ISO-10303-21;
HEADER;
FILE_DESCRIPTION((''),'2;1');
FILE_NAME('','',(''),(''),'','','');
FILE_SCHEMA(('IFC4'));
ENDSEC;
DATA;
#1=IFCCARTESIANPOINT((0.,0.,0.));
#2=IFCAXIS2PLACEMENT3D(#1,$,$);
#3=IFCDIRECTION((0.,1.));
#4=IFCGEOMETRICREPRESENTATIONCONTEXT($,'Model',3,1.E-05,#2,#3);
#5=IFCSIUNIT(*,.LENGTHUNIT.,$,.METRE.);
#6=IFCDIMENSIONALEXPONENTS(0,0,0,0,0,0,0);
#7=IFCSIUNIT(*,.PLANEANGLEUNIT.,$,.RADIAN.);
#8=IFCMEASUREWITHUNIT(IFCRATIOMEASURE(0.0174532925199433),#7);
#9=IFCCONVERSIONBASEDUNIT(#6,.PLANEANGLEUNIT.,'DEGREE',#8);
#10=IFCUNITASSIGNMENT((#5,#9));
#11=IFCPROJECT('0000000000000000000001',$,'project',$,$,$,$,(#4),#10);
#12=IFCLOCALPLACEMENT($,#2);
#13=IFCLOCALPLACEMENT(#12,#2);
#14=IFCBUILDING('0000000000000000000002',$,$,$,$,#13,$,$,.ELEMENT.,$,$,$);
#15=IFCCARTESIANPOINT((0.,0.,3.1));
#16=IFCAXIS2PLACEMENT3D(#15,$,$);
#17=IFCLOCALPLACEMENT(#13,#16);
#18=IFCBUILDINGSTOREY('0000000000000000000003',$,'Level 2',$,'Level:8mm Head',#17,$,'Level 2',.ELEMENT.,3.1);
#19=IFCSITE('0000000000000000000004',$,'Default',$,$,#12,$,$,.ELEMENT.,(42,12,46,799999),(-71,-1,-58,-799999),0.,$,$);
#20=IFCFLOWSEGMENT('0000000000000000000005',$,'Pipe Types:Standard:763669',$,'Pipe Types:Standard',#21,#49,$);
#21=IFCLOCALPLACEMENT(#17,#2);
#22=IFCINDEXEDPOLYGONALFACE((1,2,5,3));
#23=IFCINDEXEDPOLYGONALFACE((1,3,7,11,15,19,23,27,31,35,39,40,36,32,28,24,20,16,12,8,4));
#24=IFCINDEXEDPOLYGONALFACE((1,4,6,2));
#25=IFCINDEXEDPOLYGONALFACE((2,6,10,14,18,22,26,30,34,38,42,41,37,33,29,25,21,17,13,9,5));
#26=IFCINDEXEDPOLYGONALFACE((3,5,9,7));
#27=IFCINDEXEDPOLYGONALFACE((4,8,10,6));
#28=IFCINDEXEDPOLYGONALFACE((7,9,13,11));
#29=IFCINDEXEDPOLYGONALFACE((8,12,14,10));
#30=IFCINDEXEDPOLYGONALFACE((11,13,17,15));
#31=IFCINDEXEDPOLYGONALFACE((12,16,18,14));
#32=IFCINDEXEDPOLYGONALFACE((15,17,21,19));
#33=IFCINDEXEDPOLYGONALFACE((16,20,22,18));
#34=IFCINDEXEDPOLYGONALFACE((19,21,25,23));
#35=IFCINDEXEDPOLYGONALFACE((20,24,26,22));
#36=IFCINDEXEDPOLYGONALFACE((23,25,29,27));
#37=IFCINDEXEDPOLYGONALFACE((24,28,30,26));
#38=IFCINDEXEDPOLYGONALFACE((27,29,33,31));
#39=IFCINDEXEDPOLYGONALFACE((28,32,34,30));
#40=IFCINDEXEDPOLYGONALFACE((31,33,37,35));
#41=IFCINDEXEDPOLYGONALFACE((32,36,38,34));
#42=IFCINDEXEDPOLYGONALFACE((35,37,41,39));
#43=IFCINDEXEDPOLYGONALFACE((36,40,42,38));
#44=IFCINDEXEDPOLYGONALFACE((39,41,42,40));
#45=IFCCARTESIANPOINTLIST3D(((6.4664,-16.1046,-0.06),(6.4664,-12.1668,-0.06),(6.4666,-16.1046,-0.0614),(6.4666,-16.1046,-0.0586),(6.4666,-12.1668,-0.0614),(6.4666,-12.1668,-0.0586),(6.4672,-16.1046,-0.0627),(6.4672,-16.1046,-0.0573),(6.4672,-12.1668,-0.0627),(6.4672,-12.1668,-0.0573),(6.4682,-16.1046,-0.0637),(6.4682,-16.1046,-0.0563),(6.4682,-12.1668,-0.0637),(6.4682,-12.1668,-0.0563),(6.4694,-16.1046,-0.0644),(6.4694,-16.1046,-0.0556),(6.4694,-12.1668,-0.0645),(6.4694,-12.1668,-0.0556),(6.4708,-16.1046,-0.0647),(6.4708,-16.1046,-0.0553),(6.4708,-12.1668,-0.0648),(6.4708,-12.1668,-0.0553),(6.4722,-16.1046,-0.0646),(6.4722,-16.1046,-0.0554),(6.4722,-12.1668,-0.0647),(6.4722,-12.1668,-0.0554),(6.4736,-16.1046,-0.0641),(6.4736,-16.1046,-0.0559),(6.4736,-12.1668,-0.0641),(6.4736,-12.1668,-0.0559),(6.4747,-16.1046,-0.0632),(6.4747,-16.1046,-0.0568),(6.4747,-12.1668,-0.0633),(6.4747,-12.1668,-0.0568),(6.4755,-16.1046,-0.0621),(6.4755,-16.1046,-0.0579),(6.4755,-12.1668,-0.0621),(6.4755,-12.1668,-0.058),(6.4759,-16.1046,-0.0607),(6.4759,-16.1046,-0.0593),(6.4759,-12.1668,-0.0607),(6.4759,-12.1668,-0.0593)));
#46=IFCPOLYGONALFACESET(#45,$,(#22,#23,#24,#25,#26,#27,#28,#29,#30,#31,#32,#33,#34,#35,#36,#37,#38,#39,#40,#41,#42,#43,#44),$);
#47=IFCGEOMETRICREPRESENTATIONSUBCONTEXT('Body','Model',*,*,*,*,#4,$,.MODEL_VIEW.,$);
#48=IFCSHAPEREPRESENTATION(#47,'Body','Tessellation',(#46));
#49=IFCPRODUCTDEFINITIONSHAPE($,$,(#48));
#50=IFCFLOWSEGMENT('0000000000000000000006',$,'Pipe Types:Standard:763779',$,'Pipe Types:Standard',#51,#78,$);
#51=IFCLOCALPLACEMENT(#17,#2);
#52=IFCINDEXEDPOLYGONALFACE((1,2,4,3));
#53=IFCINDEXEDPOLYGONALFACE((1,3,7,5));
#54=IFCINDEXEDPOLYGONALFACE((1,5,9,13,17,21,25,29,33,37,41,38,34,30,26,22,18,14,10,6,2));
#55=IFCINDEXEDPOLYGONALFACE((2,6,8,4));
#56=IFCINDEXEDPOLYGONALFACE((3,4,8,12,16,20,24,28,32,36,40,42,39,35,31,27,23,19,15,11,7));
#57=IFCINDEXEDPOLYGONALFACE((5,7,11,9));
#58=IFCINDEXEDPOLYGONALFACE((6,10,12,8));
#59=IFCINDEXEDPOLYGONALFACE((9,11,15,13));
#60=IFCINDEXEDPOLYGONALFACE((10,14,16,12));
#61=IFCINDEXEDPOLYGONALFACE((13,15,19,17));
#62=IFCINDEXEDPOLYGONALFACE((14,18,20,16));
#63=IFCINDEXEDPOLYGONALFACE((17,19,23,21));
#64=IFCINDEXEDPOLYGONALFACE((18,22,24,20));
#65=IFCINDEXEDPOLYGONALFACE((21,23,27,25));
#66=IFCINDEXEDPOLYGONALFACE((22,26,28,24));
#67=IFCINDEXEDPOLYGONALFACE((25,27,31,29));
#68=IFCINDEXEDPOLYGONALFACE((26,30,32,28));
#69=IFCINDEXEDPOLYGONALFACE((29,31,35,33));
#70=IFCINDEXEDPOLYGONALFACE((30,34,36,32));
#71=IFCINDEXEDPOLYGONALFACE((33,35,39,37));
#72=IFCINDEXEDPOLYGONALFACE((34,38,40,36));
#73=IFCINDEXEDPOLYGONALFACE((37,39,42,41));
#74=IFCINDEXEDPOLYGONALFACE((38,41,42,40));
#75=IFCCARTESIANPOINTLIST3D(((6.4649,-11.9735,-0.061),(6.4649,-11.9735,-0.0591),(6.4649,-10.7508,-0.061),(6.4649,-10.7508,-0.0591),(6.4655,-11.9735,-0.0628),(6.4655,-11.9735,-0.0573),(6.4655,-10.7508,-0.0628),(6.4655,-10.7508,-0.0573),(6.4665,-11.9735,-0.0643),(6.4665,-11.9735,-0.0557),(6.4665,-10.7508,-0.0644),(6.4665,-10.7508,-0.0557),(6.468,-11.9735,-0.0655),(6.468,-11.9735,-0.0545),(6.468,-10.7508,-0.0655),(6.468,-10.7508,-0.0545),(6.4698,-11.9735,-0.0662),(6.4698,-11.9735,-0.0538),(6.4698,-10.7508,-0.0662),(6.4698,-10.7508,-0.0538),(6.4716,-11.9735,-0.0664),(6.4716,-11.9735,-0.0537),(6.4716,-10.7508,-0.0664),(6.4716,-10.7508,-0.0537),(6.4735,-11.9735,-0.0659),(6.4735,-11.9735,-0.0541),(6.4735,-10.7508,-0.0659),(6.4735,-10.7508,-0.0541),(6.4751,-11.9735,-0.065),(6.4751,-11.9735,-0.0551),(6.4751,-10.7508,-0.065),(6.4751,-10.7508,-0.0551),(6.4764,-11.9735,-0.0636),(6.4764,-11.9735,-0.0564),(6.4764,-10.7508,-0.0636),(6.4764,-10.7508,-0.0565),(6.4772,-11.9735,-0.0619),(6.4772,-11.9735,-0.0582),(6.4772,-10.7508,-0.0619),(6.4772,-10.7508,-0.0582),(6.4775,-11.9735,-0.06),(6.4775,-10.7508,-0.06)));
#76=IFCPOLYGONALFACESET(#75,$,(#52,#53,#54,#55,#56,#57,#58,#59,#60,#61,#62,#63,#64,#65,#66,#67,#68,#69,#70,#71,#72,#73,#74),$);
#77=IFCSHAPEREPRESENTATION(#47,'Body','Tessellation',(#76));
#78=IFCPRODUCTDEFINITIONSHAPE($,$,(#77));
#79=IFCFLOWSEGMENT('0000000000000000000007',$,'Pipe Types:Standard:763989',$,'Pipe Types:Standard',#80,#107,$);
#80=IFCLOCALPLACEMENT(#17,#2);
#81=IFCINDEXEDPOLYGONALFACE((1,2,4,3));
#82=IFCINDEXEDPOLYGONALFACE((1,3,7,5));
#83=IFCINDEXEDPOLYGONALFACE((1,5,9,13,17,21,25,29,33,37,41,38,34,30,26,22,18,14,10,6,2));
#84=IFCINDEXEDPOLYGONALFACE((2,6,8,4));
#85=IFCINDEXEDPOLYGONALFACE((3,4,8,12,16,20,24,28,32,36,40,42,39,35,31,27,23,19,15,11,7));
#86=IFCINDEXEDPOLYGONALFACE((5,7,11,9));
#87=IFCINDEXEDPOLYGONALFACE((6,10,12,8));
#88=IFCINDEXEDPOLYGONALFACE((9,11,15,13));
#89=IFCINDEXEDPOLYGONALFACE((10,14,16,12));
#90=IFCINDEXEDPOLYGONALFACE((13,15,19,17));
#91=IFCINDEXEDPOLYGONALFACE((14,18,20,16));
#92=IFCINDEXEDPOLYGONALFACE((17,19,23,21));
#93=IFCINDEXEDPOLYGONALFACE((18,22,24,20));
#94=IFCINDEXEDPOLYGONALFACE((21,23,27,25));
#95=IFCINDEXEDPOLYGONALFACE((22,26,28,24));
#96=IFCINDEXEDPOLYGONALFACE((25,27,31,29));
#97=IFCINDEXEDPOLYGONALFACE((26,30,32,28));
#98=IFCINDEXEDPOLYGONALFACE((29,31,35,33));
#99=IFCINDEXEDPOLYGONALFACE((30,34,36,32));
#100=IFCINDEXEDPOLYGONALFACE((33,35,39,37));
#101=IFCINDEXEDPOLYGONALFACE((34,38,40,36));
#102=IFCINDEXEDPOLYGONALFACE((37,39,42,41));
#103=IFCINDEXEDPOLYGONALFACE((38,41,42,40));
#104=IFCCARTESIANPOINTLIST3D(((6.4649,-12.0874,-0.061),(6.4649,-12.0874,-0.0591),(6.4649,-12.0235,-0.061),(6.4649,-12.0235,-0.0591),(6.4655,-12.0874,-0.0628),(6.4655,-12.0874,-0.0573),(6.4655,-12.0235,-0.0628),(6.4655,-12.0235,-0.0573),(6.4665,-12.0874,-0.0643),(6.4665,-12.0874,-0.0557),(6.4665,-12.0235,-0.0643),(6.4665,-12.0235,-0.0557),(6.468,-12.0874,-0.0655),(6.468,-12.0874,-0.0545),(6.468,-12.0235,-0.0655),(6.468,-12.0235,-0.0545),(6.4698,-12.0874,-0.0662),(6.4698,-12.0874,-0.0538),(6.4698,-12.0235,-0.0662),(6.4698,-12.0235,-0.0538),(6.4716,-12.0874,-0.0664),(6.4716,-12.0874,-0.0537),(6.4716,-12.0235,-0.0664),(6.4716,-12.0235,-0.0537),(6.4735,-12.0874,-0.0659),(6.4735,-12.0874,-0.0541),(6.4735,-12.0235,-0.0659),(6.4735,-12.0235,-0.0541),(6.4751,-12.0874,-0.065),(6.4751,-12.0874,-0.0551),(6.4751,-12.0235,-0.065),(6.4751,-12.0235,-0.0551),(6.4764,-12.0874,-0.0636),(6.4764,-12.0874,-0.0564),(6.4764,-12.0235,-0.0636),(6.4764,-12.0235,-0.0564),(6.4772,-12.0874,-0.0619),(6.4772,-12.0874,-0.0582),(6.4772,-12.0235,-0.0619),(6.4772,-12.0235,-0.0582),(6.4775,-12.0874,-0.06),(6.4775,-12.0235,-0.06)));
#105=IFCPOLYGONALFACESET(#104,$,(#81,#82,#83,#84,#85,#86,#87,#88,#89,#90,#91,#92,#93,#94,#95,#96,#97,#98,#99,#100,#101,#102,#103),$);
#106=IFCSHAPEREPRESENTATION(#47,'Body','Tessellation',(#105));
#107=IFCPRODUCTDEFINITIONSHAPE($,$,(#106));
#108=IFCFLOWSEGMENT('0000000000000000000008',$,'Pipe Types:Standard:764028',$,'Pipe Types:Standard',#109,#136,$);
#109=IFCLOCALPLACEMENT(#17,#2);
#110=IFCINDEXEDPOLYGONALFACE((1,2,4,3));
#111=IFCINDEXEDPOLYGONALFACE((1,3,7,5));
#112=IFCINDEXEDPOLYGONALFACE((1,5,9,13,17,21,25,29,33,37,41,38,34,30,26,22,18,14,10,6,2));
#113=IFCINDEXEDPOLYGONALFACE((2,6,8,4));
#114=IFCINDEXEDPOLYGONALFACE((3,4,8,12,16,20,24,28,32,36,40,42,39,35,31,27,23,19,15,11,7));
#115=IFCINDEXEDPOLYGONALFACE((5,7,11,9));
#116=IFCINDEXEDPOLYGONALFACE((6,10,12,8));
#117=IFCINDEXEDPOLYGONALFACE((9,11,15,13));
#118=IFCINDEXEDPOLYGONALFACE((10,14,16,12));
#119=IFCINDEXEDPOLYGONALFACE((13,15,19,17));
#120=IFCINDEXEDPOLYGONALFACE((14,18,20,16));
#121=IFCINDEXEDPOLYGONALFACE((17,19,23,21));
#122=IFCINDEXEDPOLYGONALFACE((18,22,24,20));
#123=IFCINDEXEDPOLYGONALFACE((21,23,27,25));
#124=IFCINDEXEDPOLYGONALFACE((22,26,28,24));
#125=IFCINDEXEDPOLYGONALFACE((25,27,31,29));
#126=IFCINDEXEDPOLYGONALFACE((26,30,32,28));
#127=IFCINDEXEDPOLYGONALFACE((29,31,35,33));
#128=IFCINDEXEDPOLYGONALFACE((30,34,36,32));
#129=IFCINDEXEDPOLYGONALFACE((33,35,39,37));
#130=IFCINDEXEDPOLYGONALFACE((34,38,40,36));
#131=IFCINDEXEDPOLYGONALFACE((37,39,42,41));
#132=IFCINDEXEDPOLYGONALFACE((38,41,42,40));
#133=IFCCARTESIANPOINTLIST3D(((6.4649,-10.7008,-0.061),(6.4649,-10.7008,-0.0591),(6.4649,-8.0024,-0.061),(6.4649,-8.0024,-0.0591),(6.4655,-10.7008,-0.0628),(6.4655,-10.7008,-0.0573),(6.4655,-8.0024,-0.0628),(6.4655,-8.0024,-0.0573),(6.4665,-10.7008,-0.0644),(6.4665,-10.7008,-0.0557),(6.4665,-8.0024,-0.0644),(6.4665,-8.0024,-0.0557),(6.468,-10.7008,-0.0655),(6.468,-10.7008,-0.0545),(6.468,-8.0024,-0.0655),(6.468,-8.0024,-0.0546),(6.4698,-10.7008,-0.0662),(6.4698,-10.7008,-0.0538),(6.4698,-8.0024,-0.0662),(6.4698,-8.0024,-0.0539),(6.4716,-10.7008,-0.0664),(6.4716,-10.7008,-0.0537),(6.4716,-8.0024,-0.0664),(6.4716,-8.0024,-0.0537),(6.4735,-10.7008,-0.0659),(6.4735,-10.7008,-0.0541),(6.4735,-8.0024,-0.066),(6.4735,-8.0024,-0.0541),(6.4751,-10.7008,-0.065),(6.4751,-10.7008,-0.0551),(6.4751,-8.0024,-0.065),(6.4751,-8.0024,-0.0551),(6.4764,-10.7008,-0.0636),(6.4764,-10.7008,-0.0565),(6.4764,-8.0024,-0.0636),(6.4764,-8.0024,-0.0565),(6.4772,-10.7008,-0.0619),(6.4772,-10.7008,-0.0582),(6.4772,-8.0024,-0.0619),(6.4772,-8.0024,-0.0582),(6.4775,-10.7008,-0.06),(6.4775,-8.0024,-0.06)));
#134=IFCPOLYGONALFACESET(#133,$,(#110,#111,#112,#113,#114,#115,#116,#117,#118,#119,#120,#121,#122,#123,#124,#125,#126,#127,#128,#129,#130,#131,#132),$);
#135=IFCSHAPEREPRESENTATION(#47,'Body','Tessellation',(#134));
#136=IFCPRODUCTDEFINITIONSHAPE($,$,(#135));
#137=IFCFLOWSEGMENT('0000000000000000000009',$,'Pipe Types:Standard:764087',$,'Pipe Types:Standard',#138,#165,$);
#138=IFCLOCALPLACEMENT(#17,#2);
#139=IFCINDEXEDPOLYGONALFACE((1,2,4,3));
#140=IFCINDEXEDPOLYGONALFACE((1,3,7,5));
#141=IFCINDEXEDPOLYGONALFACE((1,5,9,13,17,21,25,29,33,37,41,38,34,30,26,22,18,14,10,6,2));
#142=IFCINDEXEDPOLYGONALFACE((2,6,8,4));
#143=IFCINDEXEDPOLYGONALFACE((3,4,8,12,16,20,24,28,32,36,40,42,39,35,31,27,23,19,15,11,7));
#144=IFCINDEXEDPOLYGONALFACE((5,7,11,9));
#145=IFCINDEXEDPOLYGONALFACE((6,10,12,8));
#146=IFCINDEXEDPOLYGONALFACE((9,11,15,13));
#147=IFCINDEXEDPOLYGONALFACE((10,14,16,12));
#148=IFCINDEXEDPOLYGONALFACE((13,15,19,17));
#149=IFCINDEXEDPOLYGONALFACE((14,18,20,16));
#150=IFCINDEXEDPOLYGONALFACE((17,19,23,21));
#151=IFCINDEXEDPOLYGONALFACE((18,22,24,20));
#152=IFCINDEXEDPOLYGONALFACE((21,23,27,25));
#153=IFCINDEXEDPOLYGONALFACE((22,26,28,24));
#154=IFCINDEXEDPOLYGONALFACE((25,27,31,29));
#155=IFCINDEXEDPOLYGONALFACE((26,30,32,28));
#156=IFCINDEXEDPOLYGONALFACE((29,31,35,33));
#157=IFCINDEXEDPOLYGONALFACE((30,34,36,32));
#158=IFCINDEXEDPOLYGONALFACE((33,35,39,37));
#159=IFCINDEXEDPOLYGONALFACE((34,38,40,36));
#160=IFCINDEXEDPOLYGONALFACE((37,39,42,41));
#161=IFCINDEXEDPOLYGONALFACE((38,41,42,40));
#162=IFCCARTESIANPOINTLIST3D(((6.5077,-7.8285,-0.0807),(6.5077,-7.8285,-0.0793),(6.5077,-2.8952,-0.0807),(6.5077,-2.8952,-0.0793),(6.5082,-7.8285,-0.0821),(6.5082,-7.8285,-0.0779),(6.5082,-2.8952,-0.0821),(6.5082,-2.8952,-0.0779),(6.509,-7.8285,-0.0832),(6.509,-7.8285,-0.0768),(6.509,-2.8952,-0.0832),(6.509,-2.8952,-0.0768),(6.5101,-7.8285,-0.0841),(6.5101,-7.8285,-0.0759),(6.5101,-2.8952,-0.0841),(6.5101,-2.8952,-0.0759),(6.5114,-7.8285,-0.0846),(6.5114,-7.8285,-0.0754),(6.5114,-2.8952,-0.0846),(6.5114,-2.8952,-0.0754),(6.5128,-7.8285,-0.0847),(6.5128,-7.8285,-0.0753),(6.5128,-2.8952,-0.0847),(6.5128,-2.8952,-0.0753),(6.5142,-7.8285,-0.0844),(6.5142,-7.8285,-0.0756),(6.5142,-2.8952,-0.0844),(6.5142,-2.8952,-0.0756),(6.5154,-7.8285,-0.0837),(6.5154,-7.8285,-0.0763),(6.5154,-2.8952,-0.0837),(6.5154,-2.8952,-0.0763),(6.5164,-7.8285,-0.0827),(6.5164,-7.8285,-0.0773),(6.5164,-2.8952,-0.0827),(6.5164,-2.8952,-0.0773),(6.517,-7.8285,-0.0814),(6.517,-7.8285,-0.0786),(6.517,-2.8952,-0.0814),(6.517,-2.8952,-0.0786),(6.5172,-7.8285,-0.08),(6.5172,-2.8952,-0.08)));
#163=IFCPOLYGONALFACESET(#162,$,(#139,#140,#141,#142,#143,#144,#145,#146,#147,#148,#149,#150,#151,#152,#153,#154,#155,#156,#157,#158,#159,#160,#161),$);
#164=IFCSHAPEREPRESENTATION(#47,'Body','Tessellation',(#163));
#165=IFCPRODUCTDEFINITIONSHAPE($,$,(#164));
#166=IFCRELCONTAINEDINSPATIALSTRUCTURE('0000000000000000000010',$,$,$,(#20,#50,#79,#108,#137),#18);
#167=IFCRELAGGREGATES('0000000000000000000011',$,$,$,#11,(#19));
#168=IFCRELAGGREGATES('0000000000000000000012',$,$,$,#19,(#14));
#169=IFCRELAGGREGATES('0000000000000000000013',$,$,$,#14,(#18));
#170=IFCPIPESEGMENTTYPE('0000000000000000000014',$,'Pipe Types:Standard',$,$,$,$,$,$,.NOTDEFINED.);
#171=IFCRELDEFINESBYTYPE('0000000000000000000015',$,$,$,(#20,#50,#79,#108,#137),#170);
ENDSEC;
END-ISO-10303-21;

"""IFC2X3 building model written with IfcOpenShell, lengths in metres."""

from ifc_helpers import new_model, entity, si_unit, converted_unit, direction, frame, origin, origin_2d_with_axis, place, context, subcontext, project, spatial, circle, extrude, type_object, element, save


model = new_model("IFC2X3")

# Units and contexts
model_context = context("Model", 3, precision=1e-05, world=origin(), true_north=direction((0.0, 1.0)))
body_context = subcontext(model_context, "Body", "Model", "MODEL_VIEW")
ifc_project = project(units=[si_unit("LENGTHUNIT", "METRE"), converted_unit("PLANEANGLEUNIT", "DEGREE", entity("IfcRatioMeasure", 0.0174532925199433), si_unit("PLANEANGLEUNIT", "RADIAN"), dimensions=[0, 0, 0, 0, 0, 0, 0])], contexts=[model_context])

# Site, building, storey
site_placement = place(None, origin())
site = spatial("IfcSite", under=ifc_project, at=site_placement, Name="Default", CompositionType="ELEMENT", RefLatitude=(42, 12, 46, 799999), RefLongitude=(-71, -1, -58, -799999), RefElevation=0.0)
building_placement = place(site_placement, origin())
building = spatial("IfcBuilding", under=site, at=building_placement, CompositionType="ELEMENT")
storey_placement = place(building_placement, frame((0.0, 0.0, 3.1)))
storey = spatial("IfcBuildingStorey", under=building, at=storey_placement, Name="Level 2", ObjectType="Level:8mm Head", LongName="Level 2", CompositionType="ELEMENT", Elevation=3.1)

# Flow segments
pipe_segment_type = type_object("IfcPipeSegmentType", Name="Pipe Types:Standard", PredefinedType="NOTDEFINED")
flow_segment_1_placement = place(storey_placement, origin())
element("IfcFlowSegment", 1, at=flow_segment_1_placement, inside=storey, type_object=pipe_segment_type, Name="Pipe Types:Standard:763669", ObjectType="Pipe Types:Standard", context=body_context, shape_type="SweptSolid", body=[
    extrude(circle(Radius=0.0048, at=origin_2d_with_axis()), frame((6.4712, -16.1046, -0.06), z_axis=(0.0, 1.0, -0.000006), x_axis=(-1.0, 0.0, 0.0)), (0.0, 0.0, 1.0), 3.9377),
])
flow_segment_2_placement = place(storey_placement, origin())
element("IfcFlowSegment", 2, at=flow_segment_2_placement, inside=storey, type_object=pipe_segment_type, Name="Pipe Types:Standard:763779", ObjectType="Pipe Types:Standard", context=body_context, shape_type="SweptSolid", body=[
    extrude(circle(Radius=0.0063, at=origin_2d_with_axis()), frame((6.4712, -11.9735, -0.06), z_axis=(0.0, 1.0, -0.000005), x_axis=(1.0, 0.0, 0.0)), (0.0, 0.0, 1.0), 1.2227),
])
flow_segment_3_placement = place(storey_placement, origin())
element("IfcFlowSegment", 3, at=flow_segment_3_placement, inside=storey, type_object=pipe_segment_type, Name="Pipe Types:Standard:763989", ObjectType="Pipe Types:Standard", context=body_context, shape_type="SweptSolid", body=[
    extrude(circle(Radius=0.0063, at=origin_2d_with_axis()), frame((6.4712, -12.0874, -0.06), z_axis=(0.0, 1.0, 0.0), x_axis=(1.0, 0.0, 0.0)), (0.0, 0.0, 1.0), 0.0639),
])
flow_segment_4_placement = place(storey_placement, origin())
element("IfcFlowSegment", 4, at=flow_segment_4_placement, inside=storey, type_object=pipe_segment_type, Name="Pipe Types:Standard:764028", ObjectType="Pipe Types:Standard", context=body_context, shape_type="SweptSolid", body=[
    extrude(circle(Radius=0.0063, at=origin_2d_with_axis()), frame((6.4712, -10.7008, -0.06), z_axis=(0.0, 1.0, -0.000006), x_axis=(1.0, 0.0, 0.0)), (0.0, 0.0, 1.0), 2.6985),
])
flow_segment_5_placement = place(storey_placement, origin())
element("IfcFlowSegment", 5, at=flow_segment_5_placement, inside=storey, type_object=pipe_segment_type, Name="Pipe Types:Standard:764087", ObjectType="Pipe Types:Standard", context=body_context, shape_type="SweptSolid", body=[
    extrude(circle(Radius=0.0048, at=origin_2d_with_axis()), frame((6.5125, -7.8285, -0.08), z_axis=(0.0, 1.0, 0.0), x_axis=(1.0, 0.0, 0.0)), (0.0, 0.0, 1.0), 4.9333),
])

save(model, "model.ifc")
